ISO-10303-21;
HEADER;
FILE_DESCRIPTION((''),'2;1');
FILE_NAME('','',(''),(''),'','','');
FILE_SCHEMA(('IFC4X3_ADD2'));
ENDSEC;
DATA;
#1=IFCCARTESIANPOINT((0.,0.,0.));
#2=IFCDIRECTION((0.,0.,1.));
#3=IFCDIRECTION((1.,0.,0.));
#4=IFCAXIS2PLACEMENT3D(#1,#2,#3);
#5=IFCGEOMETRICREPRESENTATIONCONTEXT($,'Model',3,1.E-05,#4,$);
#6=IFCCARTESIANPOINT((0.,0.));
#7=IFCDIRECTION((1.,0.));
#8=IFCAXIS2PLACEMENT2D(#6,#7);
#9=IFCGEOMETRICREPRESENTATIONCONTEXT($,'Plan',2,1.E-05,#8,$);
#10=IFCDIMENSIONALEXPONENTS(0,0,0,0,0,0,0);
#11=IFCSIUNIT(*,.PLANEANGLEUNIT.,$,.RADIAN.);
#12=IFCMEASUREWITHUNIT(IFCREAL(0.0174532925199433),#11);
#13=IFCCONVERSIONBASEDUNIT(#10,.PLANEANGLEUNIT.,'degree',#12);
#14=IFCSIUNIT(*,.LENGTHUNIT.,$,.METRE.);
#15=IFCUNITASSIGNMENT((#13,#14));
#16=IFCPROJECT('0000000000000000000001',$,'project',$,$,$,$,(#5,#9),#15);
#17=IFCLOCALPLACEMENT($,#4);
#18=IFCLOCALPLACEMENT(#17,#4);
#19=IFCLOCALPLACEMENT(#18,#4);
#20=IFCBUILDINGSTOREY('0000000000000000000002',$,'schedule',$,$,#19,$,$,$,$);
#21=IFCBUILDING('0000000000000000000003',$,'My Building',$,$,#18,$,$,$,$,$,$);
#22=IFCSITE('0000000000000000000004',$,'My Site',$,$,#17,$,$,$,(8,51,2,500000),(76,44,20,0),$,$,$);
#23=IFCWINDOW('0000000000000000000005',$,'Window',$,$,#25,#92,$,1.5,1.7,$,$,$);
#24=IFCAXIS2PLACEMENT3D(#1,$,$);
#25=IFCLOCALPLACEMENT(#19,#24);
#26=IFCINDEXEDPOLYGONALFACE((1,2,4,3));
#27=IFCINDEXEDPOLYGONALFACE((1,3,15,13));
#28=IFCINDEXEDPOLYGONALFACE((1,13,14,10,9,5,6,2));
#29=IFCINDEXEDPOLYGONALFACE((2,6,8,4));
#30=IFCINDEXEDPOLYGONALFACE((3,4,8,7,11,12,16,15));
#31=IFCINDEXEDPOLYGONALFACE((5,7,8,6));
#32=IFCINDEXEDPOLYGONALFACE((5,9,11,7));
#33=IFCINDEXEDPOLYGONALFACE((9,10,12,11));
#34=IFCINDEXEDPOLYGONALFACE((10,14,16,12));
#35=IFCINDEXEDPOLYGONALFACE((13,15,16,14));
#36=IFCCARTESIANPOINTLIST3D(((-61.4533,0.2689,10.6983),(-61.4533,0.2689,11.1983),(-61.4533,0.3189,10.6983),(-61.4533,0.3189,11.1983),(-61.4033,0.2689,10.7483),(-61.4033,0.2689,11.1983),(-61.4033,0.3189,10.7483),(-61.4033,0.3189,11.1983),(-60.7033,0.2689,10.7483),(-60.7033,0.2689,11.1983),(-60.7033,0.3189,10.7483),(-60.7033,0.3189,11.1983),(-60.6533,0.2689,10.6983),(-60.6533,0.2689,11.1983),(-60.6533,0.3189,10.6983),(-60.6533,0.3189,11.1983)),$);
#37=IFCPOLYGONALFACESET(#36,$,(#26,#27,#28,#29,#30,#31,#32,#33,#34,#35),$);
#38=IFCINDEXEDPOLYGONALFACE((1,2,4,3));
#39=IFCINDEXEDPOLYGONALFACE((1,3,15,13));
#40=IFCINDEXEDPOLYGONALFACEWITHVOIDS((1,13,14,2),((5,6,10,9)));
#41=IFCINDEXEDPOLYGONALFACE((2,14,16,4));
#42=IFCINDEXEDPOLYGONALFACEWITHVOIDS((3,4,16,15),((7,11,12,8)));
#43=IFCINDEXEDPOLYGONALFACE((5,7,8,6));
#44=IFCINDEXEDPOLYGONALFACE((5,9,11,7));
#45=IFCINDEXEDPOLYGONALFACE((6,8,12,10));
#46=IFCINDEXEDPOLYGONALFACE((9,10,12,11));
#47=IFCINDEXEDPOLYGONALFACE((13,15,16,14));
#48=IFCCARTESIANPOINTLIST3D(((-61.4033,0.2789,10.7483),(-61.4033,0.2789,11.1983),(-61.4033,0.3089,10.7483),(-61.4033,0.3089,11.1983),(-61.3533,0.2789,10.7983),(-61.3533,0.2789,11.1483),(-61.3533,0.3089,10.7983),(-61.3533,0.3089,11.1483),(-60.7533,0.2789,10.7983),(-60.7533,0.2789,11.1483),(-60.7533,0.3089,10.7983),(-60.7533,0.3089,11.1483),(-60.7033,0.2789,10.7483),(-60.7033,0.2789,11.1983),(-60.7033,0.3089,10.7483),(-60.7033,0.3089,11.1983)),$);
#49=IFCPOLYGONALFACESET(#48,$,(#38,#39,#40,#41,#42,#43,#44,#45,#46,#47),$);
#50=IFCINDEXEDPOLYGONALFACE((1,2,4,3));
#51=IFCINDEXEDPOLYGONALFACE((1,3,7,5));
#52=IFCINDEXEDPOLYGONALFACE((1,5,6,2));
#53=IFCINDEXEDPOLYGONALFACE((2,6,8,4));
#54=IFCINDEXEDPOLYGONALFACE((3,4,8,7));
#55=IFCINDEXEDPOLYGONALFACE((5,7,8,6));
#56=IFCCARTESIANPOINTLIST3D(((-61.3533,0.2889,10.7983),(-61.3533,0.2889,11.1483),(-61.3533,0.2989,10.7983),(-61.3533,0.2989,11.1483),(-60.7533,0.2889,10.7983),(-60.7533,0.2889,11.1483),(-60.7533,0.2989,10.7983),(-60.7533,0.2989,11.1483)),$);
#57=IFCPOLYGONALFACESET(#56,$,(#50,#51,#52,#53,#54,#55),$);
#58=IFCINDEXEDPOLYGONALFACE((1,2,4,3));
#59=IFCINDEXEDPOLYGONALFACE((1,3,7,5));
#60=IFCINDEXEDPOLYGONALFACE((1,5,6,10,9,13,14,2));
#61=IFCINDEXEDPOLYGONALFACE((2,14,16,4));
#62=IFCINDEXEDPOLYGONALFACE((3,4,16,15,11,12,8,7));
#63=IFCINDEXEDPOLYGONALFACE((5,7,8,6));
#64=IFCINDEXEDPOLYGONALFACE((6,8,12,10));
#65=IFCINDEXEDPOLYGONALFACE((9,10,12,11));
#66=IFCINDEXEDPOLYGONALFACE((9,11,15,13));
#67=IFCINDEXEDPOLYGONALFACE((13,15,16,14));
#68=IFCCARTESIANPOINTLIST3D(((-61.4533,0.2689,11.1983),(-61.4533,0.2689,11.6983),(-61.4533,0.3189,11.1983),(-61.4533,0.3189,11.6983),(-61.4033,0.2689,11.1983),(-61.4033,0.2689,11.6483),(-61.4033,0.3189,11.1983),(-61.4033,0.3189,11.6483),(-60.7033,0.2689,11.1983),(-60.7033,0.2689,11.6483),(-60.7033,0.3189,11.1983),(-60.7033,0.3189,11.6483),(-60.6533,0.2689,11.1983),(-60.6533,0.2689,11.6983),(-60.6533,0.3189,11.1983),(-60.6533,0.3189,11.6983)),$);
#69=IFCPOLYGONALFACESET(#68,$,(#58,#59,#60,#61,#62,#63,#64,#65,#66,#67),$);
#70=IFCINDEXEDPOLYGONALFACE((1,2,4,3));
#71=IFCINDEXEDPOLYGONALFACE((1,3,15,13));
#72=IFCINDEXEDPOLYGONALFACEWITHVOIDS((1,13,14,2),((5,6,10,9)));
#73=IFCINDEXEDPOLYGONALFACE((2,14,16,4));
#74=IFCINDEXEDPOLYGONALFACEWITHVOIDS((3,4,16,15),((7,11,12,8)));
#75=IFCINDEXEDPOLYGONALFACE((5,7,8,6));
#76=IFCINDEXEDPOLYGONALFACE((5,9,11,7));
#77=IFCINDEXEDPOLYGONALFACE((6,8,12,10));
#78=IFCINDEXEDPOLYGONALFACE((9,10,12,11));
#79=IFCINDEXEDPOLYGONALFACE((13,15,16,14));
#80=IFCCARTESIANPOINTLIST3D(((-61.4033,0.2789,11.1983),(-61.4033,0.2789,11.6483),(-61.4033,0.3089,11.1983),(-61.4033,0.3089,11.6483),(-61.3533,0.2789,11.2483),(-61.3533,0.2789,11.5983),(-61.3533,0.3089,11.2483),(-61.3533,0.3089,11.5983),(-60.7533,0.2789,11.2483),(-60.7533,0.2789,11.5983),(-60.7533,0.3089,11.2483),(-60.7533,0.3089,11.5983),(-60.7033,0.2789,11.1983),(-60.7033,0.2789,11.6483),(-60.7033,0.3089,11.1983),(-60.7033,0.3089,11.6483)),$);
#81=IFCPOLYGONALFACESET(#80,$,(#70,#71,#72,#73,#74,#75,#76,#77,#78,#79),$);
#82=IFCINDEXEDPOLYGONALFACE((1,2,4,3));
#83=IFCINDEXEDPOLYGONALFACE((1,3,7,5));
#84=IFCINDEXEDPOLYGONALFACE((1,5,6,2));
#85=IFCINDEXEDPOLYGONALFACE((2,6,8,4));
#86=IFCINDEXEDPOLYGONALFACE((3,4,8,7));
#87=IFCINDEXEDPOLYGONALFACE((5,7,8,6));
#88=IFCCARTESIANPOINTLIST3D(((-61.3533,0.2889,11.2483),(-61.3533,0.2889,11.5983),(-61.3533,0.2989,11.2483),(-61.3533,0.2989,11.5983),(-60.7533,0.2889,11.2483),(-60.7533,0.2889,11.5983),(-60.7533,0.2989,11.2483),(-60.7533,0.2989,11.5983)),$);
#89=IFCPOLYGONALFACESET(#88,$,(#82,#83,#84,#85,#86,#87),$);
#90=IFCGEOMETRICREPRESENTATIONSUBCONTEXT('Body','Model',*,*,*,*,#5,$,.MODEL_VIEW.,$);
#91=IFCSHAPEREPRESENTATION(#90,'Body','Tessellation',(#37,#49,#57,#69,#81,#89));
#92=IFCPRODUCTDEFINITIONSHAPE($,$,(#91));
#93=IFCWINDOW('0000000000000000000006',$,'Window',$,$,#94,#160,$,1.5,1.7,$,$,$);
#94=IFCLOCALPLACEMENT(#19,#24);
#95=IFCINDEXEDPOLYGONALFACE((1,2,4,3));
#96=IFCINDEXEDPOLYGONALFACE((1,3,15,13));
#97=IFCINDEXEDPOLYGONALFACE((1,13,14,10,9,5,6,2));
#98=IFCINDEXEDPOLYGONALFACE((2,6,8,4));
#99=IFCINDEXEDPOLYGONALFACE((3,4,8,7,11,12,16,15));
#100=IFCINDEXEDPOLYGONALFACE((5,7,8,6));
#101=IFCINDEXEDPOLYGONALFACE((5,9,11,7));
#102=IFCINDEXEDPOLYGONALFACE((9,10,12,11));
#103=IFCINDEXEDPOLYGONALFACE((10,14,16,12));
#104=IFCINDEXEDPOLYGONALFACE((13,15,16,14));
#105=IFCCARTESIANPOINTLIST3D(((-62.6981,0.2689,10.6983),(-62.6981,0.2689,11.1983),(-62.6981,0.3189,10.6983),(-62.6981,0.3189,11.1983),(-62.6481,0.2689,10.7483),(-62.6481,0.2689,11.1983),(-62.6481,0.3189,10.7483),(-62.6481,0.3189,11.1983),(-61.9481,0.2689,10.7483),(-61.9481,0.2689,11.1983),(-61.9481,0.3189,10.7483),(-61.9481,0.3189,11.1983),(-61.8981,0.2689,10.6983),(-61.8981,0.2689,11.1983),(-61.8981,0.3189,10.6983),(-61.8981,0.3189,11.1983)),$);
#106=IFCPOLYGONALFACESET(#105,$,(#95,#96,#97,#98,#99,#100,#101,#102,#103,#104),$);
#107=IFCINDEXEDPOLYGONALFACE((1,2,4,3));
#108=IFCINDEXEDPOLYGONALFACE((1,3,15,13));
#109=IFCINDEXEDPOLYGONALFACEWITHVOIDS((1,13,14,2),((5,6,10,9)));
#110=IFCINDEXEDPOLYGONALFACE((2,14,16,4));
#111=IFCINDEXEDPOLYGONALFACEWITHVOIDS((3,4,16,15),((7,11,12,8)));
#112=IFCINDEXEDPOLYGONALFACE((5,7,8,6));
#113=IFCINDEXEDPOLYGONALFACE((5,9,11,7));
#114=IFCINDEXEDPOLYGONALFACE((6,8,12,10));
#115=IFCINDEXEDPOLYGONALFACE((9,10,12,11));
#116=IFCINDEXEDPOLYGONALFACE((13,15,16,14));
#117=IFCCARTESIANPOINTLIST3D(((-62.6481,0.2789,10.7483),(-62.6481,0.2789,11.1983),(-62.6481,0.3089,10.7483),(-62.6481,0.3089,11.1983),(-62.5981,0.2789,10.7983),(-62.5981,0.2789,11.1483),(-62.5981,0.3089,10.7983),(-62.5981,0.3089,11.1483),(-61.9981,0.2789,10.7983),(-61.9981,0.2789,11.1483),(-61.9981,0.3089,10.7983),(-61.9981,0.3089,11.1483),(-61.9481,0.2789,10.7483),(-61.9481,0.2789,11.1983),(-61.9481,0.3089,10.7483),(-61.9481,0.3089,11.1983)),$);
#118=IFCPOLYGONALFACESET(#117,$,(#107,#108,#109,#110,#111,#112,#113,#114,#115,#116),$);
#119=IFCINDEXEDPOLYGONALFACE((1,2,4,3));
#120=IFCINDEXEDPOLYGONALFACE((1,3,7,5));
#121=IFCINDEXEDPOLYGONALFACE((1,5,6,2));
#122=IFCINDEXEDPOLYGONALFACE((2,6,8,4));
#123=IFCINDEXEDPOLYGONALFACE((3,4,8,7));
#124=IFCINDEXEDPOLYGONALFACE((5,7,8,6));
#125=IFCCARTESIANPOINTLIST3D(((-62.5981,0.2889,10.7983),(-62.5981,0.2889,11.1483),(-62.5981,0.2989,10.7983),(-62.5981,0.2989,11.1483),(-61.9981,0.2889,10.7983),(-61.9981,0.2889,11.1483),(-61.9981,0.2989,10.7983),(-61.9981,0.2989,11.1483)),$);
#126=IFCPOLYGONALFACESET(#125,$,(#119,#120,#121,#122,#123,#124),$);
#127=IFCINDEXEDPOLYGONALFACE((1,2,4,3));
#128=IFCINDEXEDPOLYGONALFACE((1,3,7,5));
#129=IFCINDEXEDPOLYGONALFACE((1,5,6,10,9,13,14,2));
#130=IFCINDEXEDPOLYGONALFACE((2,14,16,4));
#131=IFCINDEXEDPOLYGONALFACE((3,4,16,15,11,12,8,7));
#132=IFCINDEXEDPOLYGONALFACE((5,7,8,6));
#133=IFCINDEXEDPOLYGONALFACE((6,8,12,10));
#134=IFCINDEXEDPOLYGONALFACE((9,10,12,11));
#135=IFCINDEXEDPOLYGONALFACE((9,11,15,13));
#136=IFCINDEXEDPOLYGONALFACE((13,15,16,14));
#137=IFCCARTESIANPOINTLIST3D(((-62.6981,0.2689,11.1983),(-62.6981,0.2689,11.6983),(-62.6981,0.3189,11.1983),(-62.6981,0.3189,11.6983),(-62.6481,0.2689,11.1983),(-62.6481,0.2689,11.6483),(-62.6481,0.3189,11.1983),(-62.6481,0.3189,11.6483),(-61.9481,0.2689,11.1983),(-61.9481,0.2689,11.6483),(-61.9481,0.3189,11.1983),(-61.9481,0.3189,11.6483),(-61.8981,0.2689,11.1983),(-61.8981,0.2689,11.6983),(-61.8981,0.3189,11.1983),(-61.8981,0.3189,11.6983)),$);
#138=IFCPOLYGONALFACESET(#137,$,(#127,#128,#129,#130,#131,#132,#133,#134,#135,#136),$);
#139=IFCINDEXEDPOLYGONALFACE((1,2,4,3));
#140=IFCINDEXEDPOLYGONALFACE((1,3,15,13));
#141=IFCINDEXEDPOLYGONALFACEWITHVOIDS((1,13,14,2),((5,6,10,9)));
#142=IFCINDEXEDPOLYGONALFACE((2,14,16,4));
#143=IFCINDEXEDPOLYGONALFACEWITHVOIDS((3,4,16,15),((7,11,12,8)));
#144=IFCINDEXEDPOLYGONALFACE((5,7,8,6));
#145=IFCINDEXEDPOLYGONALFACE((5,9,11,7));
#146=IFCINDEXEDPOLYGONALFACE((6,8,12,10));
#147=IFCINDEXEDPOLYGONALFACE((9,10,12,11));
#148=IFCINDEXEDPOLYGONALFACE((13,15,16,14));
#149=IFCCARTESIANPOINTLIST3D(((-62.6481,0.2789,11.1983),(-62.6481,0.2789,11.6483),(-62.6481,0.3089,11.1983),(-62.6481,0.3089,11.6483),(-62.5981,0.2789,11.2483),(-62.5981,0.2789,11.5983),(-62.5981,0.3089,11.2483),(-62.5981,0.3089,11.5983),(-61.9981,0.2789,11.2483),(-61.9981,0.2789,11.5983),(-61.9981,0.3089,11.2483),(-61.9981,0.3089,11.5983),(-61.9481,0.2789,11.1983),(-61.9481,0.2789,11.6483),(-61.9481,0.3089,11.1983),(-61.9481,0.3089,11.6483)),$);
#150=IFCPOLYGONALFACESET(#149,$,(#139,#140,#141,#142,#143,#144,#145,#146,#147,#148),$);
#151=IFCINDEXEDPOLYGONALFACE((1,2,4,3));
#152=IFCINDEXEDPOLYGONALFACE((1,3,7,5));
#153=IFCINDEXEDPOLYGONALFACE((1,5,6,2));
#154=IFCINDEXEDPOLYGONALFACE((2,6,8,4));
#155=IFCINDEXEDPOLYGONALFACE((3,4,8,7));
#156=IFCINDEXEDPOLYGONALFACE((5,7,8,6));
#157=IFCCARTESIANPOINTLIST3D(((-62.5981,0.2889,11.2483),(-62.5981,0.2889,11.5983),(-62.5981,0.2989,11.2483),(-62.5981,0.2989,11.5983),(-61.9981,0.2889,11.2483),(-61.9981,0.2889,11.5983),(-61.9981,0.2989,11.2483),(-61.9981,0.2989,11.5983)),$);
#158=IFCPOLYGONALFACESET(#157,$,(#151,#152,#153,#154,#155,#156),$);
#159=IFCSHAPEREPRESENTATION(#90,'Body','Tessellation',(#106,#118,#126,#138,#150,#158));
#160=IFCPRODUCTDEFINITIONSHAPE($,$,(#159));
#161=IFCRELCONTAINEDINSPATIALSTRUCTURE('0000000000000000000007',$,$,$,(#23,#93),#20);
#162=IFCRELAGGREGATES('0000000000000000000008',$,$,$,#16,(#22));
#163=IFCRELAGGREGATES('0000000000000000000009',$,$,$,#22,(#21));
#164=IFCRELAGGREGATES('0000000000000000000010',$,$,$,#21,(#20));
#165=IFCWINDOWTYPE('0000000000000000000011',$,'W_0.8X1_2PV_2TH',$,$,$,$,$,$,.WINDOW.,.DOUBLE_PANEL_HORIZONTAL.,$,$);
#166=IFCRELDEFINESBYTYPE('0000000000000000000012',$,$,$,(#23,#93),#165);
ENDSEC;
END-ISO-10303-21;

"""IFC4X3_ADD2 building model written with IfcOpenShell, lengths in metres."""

from ifc_helpers import new_model, entity, si_unit, converted_unit, frame, origin_with_axes, origin_2d_with_axis, place, context, subcontext, project, spatial, line, indexed_curve, outline, extrude, shape, source, transform, mapped, type_object, type_shapes, element, save


model = new_model("IFC4X3_ADD2")

# Units and contexts
model_context = context("Model", 3, precision=1e-05, world=origin_with_axes())
plan_context = context("Plan", 2, precision=1e-05, world=origin_2d_with_axis())
body_context_1 = subcontext(model_context, "Body", "Model", "MODEL_VIEW")
body_context_2 = subcontext(plan_context, "Body", "Plan", "PLAN_VIEW")
ifc_project = project(units=[converted_unit("PLANEANGLEUNIT", "degree", entity("IfcReal", 0.0174532925199433), si_unit("PLANEANGLEUNIT", "RADIAN"), dimensions=[0, 0, 0, 0, 0, 0, 0]), si_unit("LENGTHUNIT", "METRE")], contexts=[model_context, plan_context])

# Site, building, storey
site_placement = place(None, origin_with_axes())
site = spatial("IfcSite", under=ifc_project, at=site_placement, Name="My Site", RefLatitude=(8, 51, 2, 500000), RefLongitude=(76, 44, 20, 0))
building_placement = place(site_placement, origin_with_axes())
building = spatial("IfcBuilding", under=site, at=building_placement, Name="My Building")
storey_placement = place(building_placement, origin_with_axes())
storey = spatial("IfcBuildingStorey", under=building, at=storey_placement, Name="schedule")

# Windows
placement_1 = place(storey_placement, frame((-67.8485, 0.2689, 3.1152), z_axis=(0.0, 0.0, 1.0), x_axis=(1.0, 0.0, 0.0)))
window_type_1 = type_object("IfcWindowType", Name="W_0.8X1_2PV_2TH", PartitioningType="DOUBLE_PANEL_HORIZONTAL", PredefinedType="WINDOW")
shared_shape_1 = source(origin_with_axes(), body_context_1, "Body", "SweptSolid", [
    extrude(outline(indexed_curve([(0.8, 0.5), (0.8, 0.0), (0.0, 0.0), (0.0, 0.5), (0.05, 0.5), (0.05, 0.05), (0.75, 0.05), (0.75, 0.5)], segments=[line(1, 2, 3, 4, 5, 6, 7, 8, 1)])), frame((0.0, 0.0, 0.0), z_axis=(0.0, -1.0, 0.0), x_axis=(1.0, 0.0, 0.0)), (0.0, 0.0, -1.0), 0.05),
    extrude(outline(indexed_curve([(0.0, 0.0), (0.7, 0.0), (0.7, 0.45), (0.0, 0.45)], segments=[line(1, 2, 3, 4, 1)]), holes=[indexed_curve([(0.05, 0.05), (0.65, 0.05), (0.65, 0.4), (0.05, 0.4)], segments=[line(1, 2, 3, 4, 1)])]), frame((0.05, 0.01, 0.05), z_axis=(0.0, -1.0, 0.0), x_axis=(1.0, 0.0, 0.0)), (0.0, 0.0, -1.0), 0.03),
    extrude(outline(indexed_curve([(0.05, 0.05), (0.65, 0.05), (0.65, 0.4), (0.05, 0.4)], segments=[line(1, 2, 3, 4, 1)])), frame((0.05, 0.02, 0.05), z_axis=(0.0, -1.0, 0.0), x_axis=(1.0, 0.0, 0.0)), (0.0, 0.0, -1.0), 0.01),
    extrude(outline(indexed_curve([(0.0, 0.0), (0.0, 0.5), (0.8, 0.5), (0.8, 0.0), (0.75, 0.0), (0.75, 0.45), (0.05, 0.45), (0.05, 0.0)], segments=[line(1, 2, 3, 4, 5, 6, 7, 8, 1)])), frame((0.0, 0.0, 0.5), z_axis=(0.0, -1.0, 0.0), x_axis=(1.0, 0.0, 0.0)), (0.0, 0.0, -1.0), 0.05),
    extrude(outline(indexed_curve([(0.0, 0.0), (0.7, 0.0), (0.7, 0.45), (0.0, 0.45)], segments=[line(1, 2, 3, 4, 1)]), holes=[indexed_curve([(0.05, 0.05), (0.65, 0.05), (0.65, 0.4), (0.05, 0.4)], segments=[line(1, 2, 3, 4, 1)])]), frame((0.05, 0.01, 0.5), z_axis=(0.0, -1.0, 0.0), x_axis=(1.0, 0.0, 0.0)), (0.0, 0.0, -1.0), 0.03),
    extrude(outline(indexed_curve([(0.05, 0.05), (0.65, 0.05), (0.65, 0.4), (0.05, 0.4)], segments=[line(1, 2, 3, 4, 1)])), frame((0.05, 0.02, 0.5), z_axis=(0.0, -1.0, 0.0), x_axis=(1.0, 0.0, 0.0)), (0.0, 0.0, -1.0), 0.01),
])
shared_shape_2 = source(origin_with_axes(), body_context_2, "Body", "Curve2D", [
    entity("IfcIndexedPolyCurve", entity("IfcCartesianPointList2D", [[0.05, 0.0], [0.75, 0.0]])),
    entity("IfcIndexedPolyCurve", entity("IfcCartesianPointList2D", [[0.0, 0.05], [0.05, 0.05], [0.05, 0.0], [0.0, 0.0]]), [entity("IfcLineIndex", [1, 2, 3, 4, 1])]),
    entity("IfcIndexedPolyCurve", entity("IfcCartesianPointList2D", [[0.8, 0.05], [0.75, 0.05], [0.75, 0.0], [0.8, 0.0]]), [entity("IfcLineIndex", [1, 2, 3, 4, 1])]),
    entity("IfcIndexedPolyCurve", entity("IfcCartesianPointList2D", [[0.05, 0.01], [0.1, 0.01], [0.1, 0.04], [0.05, 0.04]]), [entity("IfcLineIndex", [1, 2, 3, 4, 1])]),
    entity("IfcIndexedPolyCurve", entity("IfcCartesianPointList2D", [[0.75, 0.01], [0.7, 0.01], [0.7, 0.04], [0.75, 0.04]]), [entity("IfcLineIndex", [1, 2, 3, 4, 1])]),
    entity("IfcIndexedPolyCurve", entity("IfcCartesianPointList2D", [[0.1, 0.01], [0.7, 0.01]])),
    entity("IfcIndexedPolyCurve", entity("IfcCartesianPointList2D", [[0.1, 0.04], [0.7, 0.04]])),
    entity("IfcIndexedPolyCurve", entity("IfcCartesianPointList2D", [[0.1, 0.025], [0.7, 0.025]])),
])
type_shapes(window_type_1, [shared_shape_1, shared_shape_2])
placement_2 = place(placement_1, frame((6.3952, 0.0, 7.5831), z_axis=(0.0, 0.0, 1.0), x_axis=(1.0, 0.0, 0.0)))
window_1_placement = place(placement_2, origin_with_axes())
element("IfcWindow", 1, at=window_1_placement, inside=storey, type_object=window_type_1, Name="Window", OverallHeight=1.5, OverallWidth=1.7, shapes=[
    shape(body_context_1, "Body", "MappedRepresentation", [mapped(shared_shape_1, transform((0.0, 0.0, 0.0), x_axis=(1.0, 0.0, 0.0), y_axis=(0.0, 1.0, 0.0), z_axis=(0.0, 0.0, 1.0), scale=1.0))]),
    shape(body_context_2, "Body", "MappedRepresentation", [mapped(shared_shape_2, transform((0.0, 0.0, 0.0), x_axis=(1.0, 0.0, 0.0), y_axis=(0.0, 1.0, 0.0), z_axis=(0.0, 0.0, 1.0), scale=1.0))]),
])
placement_3 = place(placement_1, frame((5.1505, 0.0, 7.5831), z_axis=(0.0, 0.0, 1.0), x_axis=(1.0, 0.0, 0.0)))
window_2_placement = place(placement_3, origin_with_axes())
element("IfcWindow", 2, at=window_2_placement, inside=storey, type_object=window_type_1, Name="Window", OverallHeight=1.5, OverallWidth=1.7, shapes=[
    shape(body_context_1, "Body", "MappedRepresentation", [mapped(shared_shape_1, transform((0.0, 0.0, 0.0), x_axis=(1.0, 0.0, 0.0), y_axis=(0.0, 1.0, 0.0), z_axis=(0.0, 0.0, 1.0), scale=1.0))]),
    shape(body_context_2, "Body", "MappedRepresentation", [mapped(shared_shape_2, transform((0.0, 0.0, 0.0), x_axis=(1.0, 0.0, 0.0), y_axis=(0.0, 1.0, 0.0), z_axis=(0.0, 0.0, 1.0), scale=1.0))]),
])

save(model, "model.ifc")
